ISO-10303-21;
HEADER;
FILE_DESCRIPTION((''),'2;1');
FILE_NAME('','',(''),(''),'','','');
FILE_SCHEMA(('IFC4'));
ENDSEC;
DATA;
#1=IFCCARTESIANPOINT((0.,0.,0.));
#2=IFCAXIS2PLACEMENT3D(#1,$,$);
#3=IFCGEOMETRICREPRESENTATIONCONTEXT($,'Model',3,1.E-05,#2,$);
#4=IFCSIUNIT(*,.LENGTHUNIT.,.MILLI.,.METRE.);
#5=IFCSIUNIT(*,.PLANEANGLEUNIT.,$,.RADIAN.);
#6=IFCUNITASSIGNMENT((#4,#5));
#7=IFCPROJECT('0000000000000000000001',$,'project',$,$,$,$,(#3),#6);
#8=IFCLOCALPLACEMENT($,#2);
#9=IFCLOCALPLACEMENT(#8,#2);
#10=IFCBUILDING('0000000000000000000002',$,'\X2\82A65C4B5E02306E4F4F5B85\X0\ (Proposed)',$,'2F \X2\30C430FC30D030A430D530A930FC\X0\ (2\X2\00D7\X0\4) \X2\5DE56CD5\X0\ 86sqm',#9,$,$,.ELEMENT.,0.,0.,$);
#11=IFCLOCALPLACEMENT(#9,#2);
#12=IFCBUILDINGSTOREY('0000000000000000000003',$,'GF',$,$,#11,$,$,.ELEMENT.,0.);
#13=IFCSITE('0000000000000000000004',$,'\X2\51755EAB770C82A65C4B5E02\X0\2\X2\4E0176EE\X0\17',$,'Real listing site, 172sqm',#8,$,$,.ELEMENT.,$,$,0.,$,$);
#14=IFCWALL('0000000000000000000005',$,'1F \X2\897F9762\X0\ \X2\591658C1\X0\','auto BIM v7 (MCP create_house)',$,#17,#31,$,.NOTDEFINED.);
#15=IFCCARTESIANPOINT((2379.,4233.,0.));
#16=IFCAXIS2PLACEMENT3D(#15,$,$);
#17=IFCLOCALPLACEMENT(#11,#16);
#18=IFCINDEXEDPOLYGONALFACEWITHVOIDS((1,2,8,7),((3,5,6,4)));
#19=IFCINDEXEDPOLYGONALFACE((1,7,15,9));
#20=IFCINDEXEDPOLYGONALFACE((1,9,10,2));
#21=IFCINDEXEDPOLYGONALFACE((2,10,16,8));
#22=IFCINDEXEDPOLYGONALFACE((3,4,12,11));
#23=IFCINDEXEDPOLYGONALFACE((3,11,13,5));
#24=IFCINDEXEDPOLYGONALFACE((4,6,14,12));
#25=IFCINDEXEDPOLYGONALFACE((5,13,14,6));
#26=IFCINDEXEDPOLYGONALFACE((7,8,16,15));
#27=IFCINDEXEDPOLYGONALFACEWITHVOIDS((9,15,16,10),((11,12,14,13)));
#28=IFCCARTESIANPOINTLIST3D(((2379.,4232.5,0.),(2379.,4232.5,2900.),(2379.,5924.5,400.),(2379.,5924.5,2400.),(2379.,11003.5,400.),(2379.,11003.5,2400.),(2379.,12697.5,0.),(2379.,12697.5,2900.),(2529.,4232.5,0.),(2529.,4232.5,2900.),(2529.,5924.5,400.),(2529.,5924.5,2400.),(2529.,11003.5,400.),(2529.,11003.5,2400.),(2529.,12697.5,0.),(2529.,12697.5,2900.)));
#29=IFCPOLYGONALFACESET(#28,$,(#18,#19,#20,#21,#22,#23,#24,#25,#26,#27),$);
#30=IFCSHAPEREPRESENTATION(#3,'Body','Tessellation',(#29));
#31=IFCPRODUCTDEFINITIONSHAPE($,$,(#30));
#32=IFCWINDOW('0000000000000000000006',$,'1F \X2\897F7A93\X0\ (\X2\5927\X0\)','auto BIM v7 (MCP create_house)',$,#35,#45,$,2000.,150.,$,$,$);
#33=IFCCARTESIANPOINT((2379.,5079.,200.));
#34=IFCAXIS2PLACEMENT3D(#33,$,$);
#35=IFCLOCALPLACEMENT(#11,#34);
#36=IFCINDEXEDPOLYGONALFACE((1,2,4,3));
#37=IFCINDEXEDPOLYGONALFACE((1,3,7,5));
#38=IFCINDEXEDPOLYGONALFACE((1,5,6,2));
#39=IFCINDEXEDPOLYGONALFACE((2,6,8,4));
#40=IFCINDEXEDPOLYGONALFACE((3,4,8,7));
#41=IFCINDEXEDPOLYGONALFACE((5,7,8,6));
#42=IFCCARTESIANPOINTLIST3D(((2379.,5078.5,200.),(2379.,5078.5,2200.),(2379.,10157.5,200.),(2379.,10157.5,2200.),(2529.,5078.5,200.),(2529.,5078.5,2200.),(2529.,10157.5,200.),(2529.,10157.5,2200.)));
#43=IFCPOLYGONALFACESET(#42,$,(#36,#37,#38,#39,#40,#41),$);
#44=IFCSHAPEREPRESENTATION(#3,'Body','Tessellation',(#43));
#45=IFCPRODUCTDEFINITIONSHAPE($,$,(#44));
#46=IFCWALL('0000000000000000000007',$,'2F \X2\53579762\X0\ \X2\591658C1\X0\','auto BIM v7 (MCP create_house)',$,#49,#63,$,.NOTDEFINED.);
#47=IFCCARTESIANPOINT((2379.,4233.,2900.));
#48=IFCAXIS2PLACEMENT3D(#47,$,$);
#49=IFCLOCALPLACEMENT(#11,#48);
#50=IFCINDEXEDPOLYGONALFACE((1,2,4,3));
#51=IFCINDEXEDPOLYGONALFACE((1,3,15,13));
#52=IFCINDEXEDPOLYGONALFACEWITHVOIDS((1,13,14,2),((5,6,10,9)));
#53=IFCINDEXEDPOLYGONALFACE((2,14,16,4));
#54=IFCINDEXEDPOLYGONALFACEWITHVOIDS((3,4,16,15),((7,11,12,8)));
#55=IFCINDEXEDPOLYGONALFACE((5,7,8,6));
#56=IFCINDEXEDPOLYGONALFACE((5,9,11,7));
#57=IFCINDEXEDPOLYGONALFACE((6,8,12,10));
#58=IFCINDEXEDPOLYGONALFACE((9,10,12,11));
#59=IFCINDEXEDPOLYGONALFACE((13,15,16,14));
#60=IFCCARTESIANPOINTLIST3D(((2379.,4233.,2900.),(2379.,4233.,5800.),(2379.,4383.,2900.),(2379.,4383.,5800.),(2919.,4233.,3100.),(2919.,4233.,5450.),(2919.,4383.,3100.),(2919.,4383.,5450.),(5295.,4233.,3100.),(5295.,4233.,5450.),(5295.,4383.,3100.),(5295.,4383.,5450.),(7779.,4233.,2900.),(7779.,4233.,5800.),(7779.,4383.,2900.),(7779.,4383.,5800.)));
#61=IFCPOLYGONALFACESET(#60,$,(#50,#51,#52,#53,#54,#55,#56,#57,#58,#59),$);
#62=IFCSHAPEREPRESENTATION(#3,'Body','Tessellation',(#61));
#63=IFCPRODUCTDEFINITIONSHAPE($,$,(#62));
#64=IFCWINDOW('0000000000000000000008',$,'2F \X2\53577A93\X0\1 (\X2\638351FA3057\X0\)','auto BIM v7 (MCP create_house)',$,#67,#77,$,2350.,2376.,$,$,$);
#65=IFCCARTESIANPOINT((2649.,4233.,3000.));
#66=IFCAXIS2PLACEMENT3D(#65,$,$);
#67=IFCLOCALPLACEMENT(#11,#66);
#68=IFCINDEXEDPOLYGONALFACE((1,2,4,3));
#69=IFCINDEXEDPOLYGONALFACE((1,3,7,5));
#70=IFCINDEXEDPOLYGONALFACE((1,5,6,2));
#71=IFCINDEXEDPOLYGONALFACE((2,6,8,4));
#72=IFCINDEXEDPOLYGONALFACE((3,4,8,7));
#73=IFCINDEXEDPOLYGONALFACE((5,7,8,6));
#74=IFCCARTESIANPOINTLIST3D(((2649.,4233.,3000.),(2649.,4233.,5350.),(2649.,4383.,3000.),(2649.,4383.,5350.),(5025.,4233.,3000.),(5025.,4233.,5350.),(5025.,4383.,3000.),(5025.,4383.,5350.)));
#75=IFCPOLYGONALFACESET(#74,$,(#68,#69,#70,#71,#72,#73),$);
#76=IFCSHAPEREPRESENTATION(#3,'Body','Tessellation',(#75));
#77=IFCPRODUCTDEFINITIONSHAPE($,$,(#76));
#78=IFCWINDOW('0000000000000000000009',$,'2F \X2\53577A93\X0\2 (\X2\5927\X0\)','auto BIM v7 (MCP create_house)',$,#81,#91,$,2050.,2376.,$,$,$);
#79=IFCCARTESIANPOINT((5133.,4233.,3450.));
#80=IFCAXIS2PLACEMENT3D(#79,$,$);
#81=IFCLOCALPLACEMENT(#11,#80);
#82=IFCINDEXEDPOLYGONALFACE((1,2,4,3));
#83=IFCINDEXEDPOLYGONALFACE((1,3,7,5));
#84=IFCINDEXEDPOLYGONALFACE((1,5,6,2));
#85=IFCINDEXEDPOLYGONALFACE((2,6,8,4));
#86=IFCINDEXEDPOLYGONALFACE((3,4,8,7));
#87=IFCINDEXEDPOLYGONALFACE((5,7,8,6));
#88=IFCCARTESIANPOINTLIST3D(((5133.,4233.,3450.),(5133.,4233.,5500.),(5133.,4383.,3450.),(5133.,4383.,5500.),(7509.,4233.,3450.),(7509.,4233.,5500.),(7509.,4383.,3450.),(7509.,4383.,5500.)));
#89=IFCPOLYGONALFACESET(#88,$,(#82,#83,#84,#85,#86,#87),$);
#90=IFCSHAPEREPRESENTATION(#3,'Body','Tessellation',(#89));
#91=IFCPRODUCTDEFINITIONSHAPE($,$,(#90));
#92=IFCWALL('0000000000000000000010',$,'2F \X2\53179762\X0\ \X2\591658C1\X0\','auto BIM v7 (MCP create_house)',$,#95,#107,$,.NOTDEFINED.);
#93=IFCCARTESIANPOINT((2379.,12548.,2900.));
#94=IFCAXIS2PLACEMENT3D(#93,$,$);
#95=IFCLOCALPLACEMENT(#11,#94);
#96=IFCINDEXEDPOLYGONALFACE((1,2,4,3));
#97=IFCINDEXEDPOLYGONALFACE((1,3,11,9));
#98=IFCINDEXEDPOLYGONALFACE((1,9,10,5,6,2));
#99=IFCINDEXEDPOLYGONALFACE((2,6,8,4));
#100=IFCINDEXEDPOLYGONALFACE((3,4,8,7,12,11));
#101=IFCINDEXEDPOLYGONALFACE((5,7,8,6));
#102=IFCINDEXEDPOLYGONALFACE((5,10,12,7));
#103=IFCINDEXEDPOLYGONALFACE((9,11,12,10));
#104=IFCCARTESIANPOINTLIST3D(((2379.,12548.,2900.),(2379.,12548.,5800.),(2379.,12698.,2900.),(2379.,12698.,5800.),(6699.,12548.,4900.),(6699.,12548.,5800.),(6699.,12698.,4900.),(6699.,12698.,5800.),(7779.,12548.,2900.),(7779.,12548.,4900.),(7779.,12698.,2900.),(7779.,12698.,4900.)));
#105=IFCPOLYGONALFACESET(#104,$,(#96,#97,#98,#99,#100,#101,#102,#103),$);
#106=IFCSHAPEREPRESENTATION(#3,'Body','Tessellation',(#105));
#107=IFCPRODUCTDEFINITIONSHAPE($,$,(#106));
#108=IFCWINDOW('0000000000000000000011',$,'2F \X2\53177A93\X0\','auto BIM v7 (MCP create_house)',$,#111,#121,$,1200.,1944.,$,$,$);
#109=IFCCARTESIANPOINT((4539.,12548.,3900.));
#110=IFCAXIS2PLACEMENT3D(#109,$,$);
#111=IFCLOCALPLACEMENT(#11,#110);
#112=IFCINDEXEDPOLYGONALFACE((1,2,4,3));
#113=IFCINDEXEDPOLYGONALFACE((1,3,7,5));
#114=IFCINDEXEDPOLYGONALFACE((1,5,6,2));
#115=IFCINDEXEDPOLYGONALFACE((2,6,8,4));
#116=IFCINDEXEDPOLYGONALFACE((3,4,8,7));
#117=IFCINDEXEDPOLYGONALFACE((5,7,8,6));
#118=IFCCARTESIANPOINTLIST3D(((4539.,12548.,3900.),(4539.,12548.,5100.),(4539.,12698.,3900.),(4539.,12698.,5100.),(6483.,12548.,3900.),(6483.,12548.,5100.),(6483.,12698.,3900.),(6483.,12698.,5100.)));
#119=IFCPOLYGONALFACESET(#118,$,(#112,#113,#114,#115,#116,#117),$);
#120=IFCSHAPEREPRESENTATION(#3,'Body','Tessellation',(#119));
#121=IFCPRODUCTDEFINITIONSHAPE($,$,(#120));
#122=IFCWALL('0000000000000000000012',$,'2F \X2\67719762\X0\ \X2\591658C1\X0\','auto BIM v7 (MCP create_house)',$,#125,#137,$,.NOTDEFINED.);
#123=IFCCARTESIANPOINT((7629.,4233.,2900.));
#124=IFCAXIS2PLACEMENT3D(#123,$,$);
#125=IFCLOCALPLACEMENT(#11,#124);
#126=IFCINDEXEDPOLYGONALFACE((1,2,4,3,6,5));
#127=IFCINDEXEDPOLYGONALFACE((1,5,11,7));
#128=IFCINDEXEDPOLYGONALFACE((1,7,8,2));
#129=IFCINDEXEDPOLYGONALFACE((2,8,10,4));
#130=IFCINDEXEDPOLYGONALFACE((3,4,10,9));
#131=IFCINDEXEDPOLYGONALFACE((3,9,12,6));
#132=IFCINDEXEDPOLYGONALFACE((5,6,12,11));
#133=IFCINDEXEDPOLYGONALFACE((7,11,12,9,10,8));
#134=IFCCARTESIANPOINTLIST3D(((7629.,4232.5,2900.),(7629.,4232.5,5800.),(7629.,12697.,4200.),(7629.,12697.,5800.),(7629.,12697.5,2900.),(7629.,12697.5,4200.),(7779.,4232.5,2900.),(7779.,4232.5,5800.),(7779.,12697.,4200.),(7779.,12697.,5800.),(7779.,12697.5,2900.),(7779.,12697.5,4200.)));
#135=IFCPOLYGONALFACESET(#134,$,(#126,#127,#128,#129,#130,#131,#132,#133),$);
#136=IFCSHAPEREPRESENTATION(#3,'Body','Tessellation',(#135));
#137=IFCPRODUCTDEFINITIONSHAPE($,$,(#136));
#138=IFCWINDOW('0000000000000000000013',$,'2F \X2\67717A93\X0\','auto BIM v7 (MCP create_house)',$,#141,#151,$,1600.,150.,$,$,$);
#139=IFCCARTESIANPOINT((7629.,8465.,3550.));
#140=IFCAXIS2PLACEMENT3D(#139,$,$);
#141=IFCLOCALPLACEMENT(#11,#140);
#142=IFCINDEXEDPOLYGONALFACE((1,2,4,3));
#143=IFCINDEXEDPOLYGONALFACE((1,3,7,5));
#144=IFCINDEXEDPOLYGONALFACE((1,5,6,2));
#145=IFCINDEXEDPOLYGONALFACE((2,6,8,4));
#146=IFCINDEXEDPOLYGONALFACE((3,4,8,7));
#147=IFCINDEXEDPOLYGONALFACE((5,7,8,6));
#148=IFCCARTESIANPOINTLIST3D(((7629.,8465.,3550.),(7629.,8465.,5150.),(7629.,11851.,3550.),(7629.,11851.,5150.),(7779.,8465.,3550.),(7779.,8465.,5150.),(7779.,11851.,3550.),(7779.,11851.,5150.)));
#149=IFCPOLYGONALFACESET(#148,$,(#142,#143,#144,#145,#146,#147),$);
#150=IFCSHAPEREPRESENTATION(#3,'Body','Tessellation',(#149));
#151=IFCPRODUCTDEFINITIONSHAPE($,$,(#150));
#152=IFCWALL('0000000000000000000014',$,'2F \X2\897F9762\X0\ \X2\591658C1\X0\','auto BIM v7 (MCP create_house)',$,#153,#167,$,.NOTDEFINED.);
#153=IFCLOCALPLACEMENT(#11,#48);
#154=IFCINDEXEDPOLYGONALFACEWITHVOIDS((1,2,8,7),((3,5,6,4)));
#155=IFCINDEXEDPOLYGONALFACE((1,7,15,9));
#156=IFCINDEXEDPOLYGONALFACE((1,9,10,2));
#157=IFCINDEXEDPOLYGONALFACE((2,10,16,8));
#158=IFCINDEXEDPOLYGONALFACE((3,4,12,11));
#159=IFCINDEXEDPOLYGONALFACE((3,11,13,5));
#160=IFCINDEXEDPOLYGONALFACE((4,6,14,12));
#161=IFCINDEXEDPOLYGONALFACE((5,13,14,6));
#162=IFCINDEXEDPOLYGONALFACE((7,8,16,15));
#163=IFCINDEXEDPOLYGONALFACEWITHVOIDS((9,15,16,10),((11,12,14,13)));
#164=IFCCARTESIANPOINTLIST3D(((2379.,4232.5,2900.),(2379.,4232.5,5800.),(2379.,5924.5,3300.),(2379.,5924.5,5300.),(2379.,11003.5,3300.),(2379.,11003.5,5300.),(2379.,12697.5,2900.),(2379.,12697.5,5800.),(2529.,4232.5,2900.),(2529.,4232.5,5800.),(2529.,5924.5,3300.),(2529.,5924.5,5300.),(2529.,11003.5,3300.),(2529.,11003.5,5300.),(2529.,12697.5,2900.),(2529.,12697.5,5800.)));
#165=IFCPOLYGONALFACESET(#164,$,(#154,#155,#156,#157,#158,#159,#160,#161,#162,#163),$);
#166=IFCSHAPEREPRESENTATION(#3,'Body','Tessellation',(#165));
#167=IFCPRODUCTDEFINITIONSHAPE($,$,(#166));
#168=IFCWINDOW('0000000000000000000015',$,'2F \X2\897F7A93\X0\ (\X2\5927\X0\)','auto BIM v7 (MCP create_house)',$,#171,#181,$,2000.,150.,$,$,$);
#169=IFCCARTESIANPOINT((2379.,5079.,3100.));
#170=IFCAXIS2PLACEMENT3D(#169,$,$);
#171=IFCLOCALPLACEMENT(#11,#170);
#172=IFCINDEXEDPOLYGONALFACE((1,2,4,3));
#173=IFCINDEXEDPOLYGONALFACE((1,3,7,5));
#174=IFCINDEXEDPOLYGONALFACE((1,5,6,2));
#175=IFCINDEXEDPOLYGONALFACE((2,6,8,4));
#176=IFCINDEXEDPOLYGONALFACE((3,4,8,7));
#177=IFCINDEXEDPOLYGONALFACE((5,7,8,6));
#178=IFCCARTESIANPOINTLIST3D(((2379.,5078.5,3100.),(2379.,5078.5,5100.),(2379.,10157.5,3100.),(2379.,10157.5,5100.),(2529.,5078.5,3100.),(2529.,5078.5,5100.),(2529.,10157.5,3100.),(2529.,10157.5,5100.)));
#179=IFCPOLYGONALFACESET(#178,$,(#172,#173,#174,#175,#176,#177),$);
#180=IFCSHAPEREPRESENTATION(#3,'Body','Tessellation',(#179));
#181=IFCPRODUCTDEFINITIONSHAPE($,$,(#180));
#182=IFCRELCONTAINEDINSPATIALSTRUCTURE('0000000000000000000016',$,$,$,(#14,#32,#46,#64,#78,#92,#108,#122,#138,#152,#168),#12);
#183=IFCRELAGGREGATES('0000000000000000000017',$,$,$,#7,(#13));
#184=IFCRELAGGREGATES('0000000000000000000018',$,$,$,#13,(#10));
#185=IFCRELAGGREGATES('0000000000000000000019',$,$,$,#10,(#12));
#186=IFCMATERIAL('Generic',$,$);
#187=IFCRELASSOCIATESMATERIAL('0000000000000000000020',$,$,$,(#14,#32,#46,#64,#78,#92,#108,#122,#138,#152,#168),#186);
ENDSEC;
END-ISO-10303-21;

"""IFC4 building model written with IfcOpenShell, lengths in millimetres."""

from ifc_helpers import new_model, si_unit, frame, frame_2d, origin, place, context, project, spatial, rectangle, extrude, material, element, fill, save


model = new_model("IFC4")

# Units and contexts
model_context = context("Model", 3, precision=1e-05, world=origin())
ifc_project = project(units=[si_unit("LENGTHUNIT", "METRE", prefix="MILLI"), si_unit("PLANEANGLEUNIT", "RADIAN")], contexts=[model_context])

# Site, building, storey
site_placement = place(None, origin())
site = spatial("IfcSite", under=ifc_project, at=site_placement, Name="兵庫県芦屋市2丁目17", ObjectType="Real listing site, 172sqm", CompositionType="ELEMENT", RefElevation=0.0)
building_placement = place(site_placement, origin())
building = spatial("IfcBuilding", under=site, at=building_placement, Name="芦屋市の住宅 (Proposed)", ObjectType="2F ツーバイフォー (2×4) 工法 86sqm", CompositionType="ELEMENT", ElevationOfRefHeight=0.0, ElevationOfTerrain=0.0)
storey_placement = place(building_placement, origin())
storey = spatial("IfcBuildingStorey", under=building, at=storey_placement, Name="GF", CompositionType="ELEMENT", Elevation=0.0)

# Shared definitions
ifc_material = material(Name="Generic")

# Wall, opening, window
wall_1_placement = place(storey_placement, frame((2379.0, 4233.0, 0.0)))
wall_1 = element("IfcWall", 1, at=wall_1_placement, inside=storey, material=ifc_material, Name="1F 西面 外壁", Description="auto BIM v7 (MCP create_house)", PredefinedType="NOTDEFINED", context=model_context, shape_type="SweptSolid", body=[
    extrude(rectangle(XDim=150.0, YDim=8465.0, at=frame_2d((75.0, 4232.0))), frame((2379.0, 4233.0, 0.0)), (0.0, 0.0, 1.0), 2900.0),
])
opening_1_placement = place(storey_placement, frame((2379.0, 5079.0, 200.0)))
opening_1 = element("IfcOpeningElement", 2, at=opening_1_placement, cuts=wall_1, PredefinedType="NOTDEFINED", context=model_context, shape_type="SweptSolid", body=[
    extrude(rectangle(XDim=150.0, YDim=5079.0, at=frame_2d((75.0, 2539.0))), frame((2379.0, 5079.0, 200.0)), (0.0, 0.0, 1.0), 2000.0),
])
window_1_placement = place(storey_placement, frame((2379.0, 5079.0, 200.0)))
window_1 = element("IfcWindow", 3, at=window_1_placement, inside=storey, material=ifc_material, Name="1F 西窓 (大)", Description="auto BIM v7 (MCP create_house)", OverallHeight=2000.0, OverallWidth=150.0, context=model_context, shape_type="SweptSolid", body=[
    extrude(rectangle(XDim=150.0, YDim=5079.0, at=frame_2d((75.0, 2539.0))), frame((2379.0, 5079.0, 200.0)), (0.0, 0.0, 1.0), 2000.0),
])
fill(opening_1, window_1)

# Wall, openings, windows
wall_2_placement = place(storey_placement, frame((2379.0, 4233.0, 2900.0)))
wall_2 = element("IfcWall", 4, at=wall_2_placement, inside=storey, material=ifc_material, Name="2F 南面 外壁", Description="auto BIM v7 (MCP create_house)", PredefinedType="NOTDEFINED", context=model_context, shape_type="SweptSolid", body=[
    extrude(rectangle(XDim=5400.0, YDim=150.0, at=frame_2d((2700.0, 75.0))), frame((2379.0, 4233.0, 2900.0)), (0.0, 0.0, 1.0), 2900.0),
])
opening_2_placement = place(storey_placement, frame((2649.0, 4233.0, 3000.0)))
opening_2 = element("IfcOpeningElement", 5, at=opening_2_placement, cuts=wall_2, PredefinedType="NOTDEFINED", context=model_context, shape_type="SweptSolid", body=[
    extrude(rectangle(XDim=2376.0, YDim=150.0, at=frame_2d((1188.0, 75.0))), frame((2649.0, 4233.0, 3000.0)), (0.0, 0.0, 1.0), 2350.0),
])
opening_3_placement = place(storey_placement, frame((5133.0, 4233.0, 3450.0)))
opening_3 = element("IfcOpeningElement", 6, at=opening_3_placement, cuts=wall_2, PredefinedType="NOTDEFINED", context=model_context, shape_type="SweptSolid", body=[
    extrude(rectangle(XDim=2376.0, YDim=150.0, at=frame_2d((1188.0, 75.0))), frame((5133.0, 4233.0, 3450.0)), (0.0, 0.0, 1.0), 2050.0),
])
window_2_placement = place(storey_placement, frame((2649.0, 4233.0, 3000.0)))
window_2 = element("IfcWindow", 7, at=window_2_placement, inside=storey, material=ifc_material, Name="2F 南窓1 (掃出し)", Description="auto BIM v7 (MCP create_house)", OverallHeight=2350.0, OverallWidth=2376.0, context=model_context, shape_type="SweptSolid", body=[
    extrude(rectangle(XDim=2376.0, YDim=150.0, at=frame_2d((1188.0, 75.0))), frame((2649.0, 4233.0, 3000.0)), (0.0, 0.0, 1.0), 2350.0),
])
fill(opening_2, window_2)
window_3_placement = place(storey_placement, frame((5133.0, 4233.0, 3450.0)))
window_3 = element("IfcWindow", 8, at=window_3_placement, inside=storey, material=ifc_material, Name="2F 南窓2 (大)", Description="auto BIM v7 (MCP create_house)", OverallHeight=2050.0, OverallWidth=2376.0, context=model_context, shape_type="SweptSolid", body=[
    extrude(rectangle(XDim=2376.0, YDim=150.0, at=frame_2d((1188.0, 75.0))), frame((5133.0, 4233.0, 3450.0)), (0.0, 0.0, 1.0), 2050.0),
])
fill(opening_3, window_3)

# Walls, openings, windows
wall_3_placement = place(storey_placement, frame((2379.0, 12548.0, 2900.0)))
wall_3 = element("IfcWall", 9, at=wall_3_placement, inside=storey, material=ifc_material, Name="2F 北面 外壁", Description="auto BIM v7 (MCP create_house)", PredefinedType="NOTDEFINED", context=model_context, shape_type="SweptSolid", body=[
    extrude(rectangle(XDim=5400.0, YDim=150.0, at=frame_2d((2700.0, 75.0))), frame((2379.0, 12548.0, 2900.0)), (0.0, 0.0, 1.0), 2900.0),
])
opening_4_placement = place(storey_placement, frame((4539.0, 12548.0, 3900.0)))
opening_4 = element("IfcOpeningElement", 10, at=opening_4_placement, cuts=wall_3, PredefinedType="NOTDEFINED", context=model_context, shape_type="SweptSolid", body=[
    extrude(rectangle(XDim=1944.0, YDim=150.0, at=frame_2d((972.0, 75.0))), frame((4539.0, 12548.0, 3900.0)), (0.0, 0.0, 1.0), 1200.0),
])
window_4_placement = place(storey_placement, frame((4539.0, 12548.0, 3900.0)))
window_4 = element("IfcWindow", 11, at=window_4_placement, inside=storey, material=ifc_material, Name="2F 北窓", Description="auto BIM v7 (MCP create_house)", OverallHeight=1200.0, OverallWidth=1944.0, context=model_context, shape_type="SweptSolid", body=[
    extrude(rectangle(XDim=1944.0, YDim=150.0, at=frame_2d((972.0, 75.0))), frame((4539.0, 12548.0, 3900.0)), (0.0, 0.0, 1.0), 1200.0),
])
fill(opening_4, window_4)
wall_4_placement = place(storey_placement, frame((7629.0, 4233.0, 2900.0)))
wall_4 = element("IfcWall", 12, at=wall_4_placement, inside=storey, material=ifc_material, Name="2F 東面 外壁", Description="auto BIM v7 (MCP create_house)", PredefinedType="NOTDEFINED", context=model_context, shape_type="SweptSolid", body=[
    extrude(rectangle(XDim=150.0, YDim=8465.0, at=frame_2d((75.0, 4232.0))), frame((7629.0, 4233.0, 2900.0)), (0.0, 0.0, 1.0), 2900.0),
])
opening_5_placement = place(storey_placement, frame((7629.0, 8465.0, 3550.0)))
opening_5 = element("IfcOpeningElement", 13, at=opening_5_placement, cuts=wall_4, PredefinedType="NOTDEFINED", context=model_context, shape_type="SweptSolid", body=[
    extrude(rectangle(XDim=150.0, YDim=3386.0, at=frame_2d((75.0, 1693.0))), frame((7629.0, 8465.0, 3550.0)), (0.0, 0.0, 1.0), 1600.0),
])
window_5_placement = place(storey_placement, frame((7629.0, 8465.0, 3550.0)))
window_5 = element("IfcWindow", 14, at=window_5_placement, inside=storey, material=ifc_material, Name="2F 東窓", Description="auto BIM v7 (MCP create_house)", OverallHeight=1600.0, OverallWidth=150.0, context=model_context, shape_type="SweptSolid", body=[
    extrude(rectangle(XDim=150.0, YDim=3386.0, at=frame_2d((75.0, 1693.0))), frame((7629.0, 8465.0, 3550.0)), (0.0, 0.0, 1.0), 1600.0),
])
fill(opening_5, window_5)
wall_5_placement = place(storey_placement, frame((2379.0, 4233.0, 2900.0)))
wall_5 = element("IfcWall", 15, at=wall_5_placement, inside=storey, material=ifc_material, Name="2F 西面 外壁", Description="auto BIM v7 (MCP create_house)", PredefinedType="NOTDEFINED", context=model_context, shape_type="SweptSolid", body=[
    extrude(rectangle(XDim=150.0, YDim=8465.0, at=frame_2d((75.0, 4232.0))), frame((2379.0, 4233.0, 2900.0)), (0.0, 0.0, 1.0), 2900.0),
])
opening_6_placement = place(storey_placement, frame((2379.0, 5079.0, 3100.0)))
opening_6 = element("IfcOpeningElement", 16, at=opening_6_placement, cuts=wall_5, PredefinedType="NOTDEFINED", context=model_context, shape_type="SweptSolid", body=[
    extrude(rectangle(XDim=150.0, YDim=5079.0, at=frame_2d((75.0, 2539.0))), frame((2379.0, 5079.0, 3100.0)), (0.0, 0.0, 1.0), 2000.0),
])
window_6_placement = place(storey_placement, frame((2379.0, 5079.0, 3100.0)))
window_6 = element("IfcWindow", 17, at=window_6_placement, inside=storey, material=ifc_material, Name="2F 西窓 (大)", Description="auto BIM v7 (MCP create_house)", OverallHeight=2000.0, OverallWidth=150.0, context=model_context, shape_type="SweptSolid", body=[
    extrude(rectangle(XDim=150.0, YDim=5079.0, at=frame_2d((75.0, 2539.0))), frame((2379.0, 5079.0, 3100.0)), (0.0, 0.0, 1.0), 2000.0),
])
fill(opening_6, window_6)

save(model, "model.ifc")
